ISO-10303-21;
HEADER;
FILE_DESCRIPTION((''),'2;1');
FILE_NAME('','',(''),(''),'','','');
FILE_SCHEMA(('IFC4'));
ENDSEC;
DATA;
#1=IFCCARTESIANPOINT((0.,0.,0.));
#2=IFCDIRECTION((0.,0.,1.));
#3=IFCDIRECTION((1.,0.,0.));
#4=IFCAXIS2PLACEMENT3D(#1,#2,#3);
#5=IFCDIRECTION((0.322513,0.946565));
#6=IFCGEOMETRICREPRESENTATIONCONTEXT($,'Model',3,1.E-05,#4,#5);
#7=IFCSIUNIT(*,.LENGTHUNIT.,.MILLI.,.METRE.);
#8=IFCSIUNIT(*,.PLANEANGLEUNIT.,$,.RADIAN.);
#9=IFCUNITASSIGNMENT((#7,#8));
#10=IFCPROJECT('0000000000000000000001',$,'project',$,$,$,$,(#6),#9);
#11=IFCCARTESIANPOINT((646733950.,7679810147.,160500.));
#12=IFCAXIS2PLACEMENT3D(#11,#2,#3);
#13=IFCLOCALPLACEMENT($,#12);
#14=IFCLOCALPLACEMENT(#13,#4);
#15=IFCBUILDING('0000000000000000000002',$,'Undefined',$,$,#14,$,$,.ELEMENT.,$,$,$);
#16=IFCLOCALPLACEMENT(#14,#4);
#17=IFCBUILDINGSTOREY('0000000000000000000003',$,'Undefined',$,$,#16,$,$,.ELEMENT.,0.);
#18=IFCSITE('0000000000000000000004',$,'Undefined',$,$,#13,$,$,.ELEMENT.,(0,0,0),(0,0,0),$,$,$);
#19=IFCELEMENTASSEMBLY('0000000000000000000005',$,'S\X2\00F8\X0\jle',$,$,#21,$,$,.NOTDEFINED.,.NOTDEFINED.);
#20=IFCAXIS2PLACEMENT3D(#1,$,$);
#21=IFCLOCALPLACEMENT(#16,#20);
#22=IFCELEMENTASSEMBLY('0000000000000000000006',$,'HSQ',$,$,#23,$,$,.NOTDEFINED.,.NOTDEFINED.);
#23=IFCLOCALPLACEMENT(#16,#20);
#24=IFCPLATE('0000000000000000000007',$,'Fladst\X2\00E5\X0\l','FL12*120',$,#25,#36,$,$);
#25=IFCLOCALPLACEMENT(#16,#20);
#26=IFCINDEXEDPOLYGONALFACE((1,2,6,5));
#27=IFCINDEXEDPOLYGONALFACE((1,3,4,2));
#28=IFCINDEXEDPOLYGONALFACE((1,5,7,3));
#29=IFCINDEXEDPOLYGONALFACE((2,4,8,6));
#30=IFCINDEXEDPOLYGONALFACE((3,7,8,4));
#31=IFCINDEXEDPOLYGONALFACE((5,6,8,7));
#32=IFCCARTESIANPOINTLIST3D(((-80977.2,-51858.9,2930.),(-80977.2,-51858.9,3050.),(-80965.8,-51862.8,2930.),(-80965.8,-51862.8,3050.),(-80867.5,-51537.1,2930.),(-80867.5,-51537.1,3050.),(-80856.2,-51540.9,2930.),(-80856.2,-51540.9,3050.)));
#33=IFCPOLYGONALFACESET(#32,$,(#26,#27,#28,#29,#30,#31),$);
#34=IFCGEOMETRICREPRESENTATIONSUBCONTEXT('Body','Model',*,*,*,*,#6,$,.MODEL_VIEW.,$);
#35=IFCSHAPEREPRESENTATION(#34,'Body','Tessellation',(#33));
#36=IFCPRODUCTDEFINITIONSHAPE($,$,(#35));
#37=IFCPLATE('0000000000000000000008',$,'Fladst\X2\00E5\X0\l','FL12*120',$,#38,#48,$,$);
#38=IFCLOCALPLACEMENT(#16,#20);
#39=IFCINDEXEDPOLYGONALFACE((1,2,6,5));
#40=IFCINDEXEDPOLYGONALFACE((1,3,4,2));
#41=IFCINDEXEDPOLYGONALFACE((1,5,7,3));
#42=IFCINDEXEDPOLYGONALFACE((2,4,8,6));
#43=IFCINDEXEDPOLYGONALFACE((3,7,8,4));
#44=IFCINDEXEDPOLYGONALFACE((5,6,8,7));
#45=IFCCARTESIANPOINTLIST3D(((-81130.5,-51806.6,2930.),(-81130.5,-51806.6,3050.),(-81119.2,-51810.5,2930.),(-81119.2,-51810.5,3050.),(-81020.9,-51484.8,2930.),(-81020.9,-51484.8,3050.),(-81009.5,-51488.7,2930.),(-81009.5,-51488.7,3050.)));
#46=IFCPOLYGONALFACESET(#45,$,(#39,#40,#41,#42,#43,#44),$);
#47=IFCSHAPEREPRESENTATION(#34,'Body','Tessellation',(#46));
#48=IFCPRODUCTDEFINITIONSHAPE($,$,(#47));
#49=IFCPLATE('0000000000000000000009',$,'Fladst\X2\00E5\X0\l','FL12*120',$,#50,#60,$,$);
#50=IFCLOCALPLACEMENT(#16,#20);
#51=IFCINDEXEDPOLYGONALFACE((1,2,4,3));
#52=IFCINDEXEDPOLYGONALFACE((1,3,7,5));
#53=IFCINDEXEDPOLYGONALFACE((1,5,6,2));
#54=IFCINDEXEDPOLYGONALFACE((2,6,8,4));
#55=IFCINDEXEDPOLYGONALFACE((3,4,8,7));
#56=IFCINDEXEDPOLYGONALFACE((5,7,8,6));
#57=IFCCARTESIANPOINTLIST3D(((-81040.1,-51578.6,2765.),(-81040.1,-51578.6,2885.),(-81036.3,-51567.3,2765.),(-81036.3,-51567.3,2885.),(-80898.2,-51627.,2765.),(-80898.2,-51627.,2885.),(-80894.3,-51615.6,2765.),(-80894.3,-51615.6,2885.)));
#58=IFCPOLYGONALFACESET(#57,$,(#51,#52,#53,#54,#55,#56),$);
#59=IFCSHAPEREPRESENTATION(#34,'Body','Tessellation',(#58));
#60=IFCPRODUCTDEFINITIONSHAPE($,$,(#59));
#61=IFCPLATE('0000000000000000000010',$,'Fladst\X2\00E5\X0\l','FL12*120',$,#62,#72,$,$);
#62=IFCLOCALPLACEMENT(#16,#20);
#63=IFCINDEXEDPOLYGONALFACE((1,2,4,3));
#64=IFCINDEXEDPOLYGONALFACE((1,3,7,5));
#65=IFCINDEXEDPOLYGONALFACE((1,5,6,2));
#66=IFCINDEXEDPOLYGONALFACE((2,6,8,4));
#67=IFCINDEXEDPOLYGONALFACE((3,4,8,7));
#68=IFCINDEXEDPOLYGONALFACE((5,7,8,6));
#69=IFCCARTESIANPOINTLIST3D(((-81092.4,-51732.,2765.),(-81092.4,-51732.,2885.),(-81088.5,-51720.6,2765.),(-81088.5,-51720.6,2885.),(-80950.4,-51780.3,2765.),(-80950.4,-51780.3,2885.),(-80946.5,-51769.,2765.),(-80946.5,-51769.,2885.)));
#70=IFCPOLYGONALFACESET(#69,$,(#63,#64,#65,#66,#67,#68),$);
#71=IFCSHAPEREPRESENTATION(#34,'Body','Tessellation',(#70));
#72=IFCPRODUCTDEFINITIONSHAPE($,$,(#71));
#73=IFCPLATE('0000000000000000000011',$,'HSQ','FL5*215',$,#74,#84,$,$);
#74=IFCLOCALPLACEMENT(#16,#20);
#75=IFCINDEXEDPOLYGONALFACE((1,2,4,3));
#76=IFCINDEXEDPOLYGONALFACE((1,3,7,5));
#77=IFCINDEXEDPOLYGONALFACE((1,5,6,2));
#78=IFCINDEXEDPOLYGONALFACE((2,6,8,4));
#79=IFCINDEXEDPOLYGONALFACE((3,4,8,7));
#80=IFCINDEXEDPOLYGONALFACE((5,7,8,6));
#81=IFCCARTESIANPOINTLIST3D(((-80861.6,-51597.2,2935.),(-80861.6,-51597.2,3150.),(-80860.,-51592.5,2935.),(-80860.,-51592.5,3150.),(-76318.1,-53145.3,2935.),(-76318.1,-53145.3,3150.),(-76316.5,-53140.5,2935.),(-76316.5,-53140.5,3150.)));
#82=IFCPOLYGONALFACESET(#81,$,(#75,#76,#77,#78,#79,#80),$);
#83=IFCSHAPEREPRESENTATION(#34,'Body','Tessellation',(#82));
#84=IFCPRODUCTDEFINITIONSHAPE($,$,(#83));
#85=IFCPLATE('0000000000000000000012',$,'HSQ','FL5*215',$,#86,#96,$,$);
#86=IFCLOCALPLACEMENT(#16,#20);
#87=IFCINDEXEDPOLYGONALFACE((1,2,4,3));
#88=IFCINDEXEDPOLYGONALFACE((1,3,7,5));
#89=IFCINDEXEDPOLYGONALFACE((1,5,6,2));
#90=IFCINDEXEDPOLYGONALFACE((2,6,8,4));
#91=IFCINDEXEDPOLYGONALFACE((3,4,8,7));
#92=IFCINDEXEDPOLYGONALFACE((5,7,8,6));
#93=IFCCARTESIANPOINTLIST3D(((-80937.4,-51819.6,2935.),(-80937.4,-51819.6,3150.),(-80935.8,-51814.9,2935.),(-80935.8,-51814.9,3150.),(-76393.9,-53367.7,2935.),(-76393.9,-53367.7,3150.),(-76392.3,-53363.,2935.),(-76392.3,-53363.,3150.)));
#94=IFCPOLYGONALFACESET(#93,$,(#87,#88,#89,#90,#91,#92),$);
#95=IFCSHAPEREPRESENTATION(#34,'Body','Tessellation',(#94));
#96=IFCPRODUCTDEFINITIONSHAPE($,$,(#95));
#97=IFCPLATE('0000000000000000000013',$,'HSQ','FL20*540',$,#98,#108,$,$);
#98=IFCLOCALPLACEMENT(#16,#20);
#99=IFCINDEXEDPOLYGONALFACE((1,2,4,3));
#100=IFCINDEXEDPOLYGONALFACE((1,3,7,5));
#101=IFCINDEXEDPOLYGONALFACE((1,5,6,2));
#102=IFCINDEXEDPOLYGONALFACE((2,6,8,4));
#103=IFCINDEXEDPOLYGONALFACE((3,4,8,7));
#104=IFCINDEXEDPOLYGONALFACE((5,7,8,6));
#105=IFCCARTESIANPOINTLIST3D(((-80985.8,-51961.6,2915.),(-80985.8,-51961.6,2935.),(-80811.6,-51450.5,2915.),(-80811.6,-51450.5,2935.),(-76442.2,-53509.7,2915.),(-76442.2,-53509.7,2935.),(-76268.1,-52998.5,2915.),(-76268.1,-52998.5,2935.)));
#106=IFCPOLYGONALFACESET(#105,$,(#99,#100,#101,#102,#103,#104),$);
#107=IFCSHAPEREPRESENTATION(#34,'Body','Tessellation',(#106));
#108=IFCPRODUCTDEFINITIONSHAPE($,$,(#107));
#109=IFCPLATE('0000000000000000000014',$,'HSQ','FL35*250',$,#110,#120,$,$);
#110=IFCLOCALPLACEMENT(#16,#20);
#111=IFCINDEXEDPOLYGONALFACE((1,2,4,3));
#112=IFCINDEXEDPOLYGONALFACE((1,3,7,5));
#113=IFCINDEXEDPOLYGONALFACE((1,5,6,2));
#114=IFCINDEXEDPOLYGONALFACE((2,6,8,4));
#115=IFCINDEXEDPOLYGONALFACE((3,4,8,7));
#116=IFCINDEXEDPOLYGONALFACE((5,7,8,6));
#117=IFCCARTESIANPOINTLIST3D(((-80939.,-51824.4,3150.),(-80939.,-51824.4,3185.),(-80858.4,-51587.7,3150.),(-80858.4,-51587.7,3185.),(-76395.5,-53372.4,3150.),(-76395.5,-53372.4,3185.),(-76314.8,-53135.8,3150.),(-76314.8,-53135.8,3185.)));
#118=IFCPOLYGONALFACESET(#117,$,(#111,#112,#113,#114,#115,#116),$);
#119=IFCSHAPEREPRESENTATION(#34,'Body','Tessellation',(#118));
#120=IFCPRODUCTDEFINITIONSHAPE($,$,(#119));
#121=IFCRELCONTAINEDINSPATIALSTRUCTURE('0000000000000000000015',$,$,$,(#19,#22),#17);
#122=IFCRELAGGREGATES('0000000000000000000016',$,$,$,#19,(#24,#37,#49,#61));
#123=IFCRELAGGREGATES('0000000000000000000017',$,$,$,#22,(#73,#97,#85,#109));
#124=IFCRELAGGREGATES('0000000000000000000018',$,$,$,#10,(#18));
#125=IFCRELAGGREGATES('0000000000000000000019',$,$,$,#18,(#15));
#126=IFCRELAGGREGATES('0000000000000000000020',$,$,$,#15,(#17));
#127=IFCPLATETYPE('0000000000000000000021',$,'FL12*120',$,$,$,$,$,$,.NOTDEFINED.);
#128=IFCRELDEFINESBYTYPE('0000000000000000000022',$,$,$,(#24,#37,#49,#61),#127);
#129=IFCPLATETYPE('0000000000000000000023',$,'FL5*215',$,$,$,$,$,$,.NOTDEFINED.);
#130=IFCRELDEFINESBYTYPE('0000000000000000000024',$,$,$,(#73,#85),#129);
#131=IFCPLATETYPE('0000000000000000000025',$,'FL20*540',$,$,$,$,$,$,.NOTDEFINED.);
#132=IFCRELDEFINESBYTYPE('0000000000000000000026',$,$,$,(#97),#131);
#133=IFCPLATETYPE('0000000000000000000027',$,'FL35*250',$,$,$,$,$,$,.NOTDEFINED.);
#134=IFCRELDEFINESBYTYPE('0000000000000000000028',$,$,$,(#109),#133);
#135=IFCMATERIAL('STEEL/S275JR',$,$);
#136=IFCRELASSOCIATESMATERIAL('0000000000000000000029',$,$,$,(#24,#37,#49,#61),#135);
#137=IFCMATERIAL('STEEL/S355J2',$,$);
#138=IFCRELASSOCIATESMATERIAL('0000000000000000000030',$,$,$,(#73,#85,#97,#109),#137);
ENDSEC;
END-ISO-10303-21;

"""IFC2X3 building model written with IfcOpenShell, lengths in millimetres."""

from ifc_helpers import new_model, si_unit, direction, frame, origin_with_axes, place, context, subcontext, project, spatial, polyline, outline, extrude, material, type_object, element, aggregate, save


model = new_model("IFC2X3")

# Units and contexts
model_context = context("Model", 3, precision=1e-05, world=origin_with_axes(), true_north=direction((0.322513, 0.946565)))
body_context = subcontext(model_context, "Body", "Model", "MODEL_VIEW")
ifc_project = project(units=[si_unit("LENGTHUNIT", "METRE", prefix="MILLI"), si_unit("PLANEANGLEUNIT", "RADIAN")], contexts=[model_context])

# Site, building, storey
site_placement = place(None, frame((646733950.0, 7679810147.0, 160500.0), z_axis=(0.0, 0.0, 1.0), x_axis=(1.0, 0.0, 0.0)))
site = spatial("IfcSite", under=ifc_project, at=site_placement, Name="Undefined", CompositionType="ELEMENT", RefLatitude=(0, 0, 0), RefLongitude=(0, 0, 0))
building_placement = place(site_placement, origin_with_axes())
building = spatial("IfcBuilding", under=site, at=building_placement, Name="Undefined", CompositionType="ELEMENT")
storey_placement = place(building_placement, origin_with_axes())
storey = spatial("IfcBuildingStorey", under=building, at=storey_placement, Name="Undefined", CompositionType="ELEMENT", Elevation=0.0)

# Element assembly
assembly_1_placement = place(storey_placement, origin_with_axes())
assembly_1 = element("IfcElementAssembly", 1, at=assembly_1_placement, inside=storey, Name="Søjle", AssemblyPlace="NOTDEFINED", PredefinedType="NOTDEFINED")

# Shared definitions
ifc_material_1 = material(Name="STEEL/S275JR")

# Element assembly
assembly_2_placement = place(storey_placement, origin_with_axes())
assembly_2 = element("IfcElementAssembly", 2, at=assembly_2_placement, inside=storey, Name="HSQ", AssemblyPlace="NOTDEFINED", PredefinedType="NOTDEFINED")

# Plates
plate_type_1 = type_object("IfcPlateType", Name="FL12*120", PredefinedType="NOTDEFINED")
plate_1_placement = place(assembly_1_placement, frame((-80861.8, -51539.0, 3050.0), z_axis=(0.946565, -0.322513, 0.0), x_axis=(-0.322513, -0.946565, 0.0)))
plate_1 = element("IfcPlate", 3, at=plate_1_placement, type_object=plate_type_1, material=ifc_material_1, Name="Fladstål", Description="FL12*120", context=body_context, shape_type="SweptSolid", body=[
    extrude(outline(polyline([(0.0, 0.0), (340.0, 0.0), (340.0, 120.0), (0.0, 120.0), (0.0, 0.0)])), frame((0.0, 0.0, -6.0), z_axis=(0.0, 0.0, 1.0), x_axis=(1.0, 0.0, 0.0)), (0.0, 0.0, 1.0), 12.0),
])
plate_2_placement = place(assembly_1_placement, frame((-81015.2, -51486.8, 3050.0), z_axis=(0.946565, -0.322513, 0.0), x_axis=(-0.322513, -0.946565, 0.0)))
plate_2 = element("IfcPlate", 4, at=plate_2_placement, type_object=plate_type_1, material=ifc_material_1, Name="Fladstål", Description="FL12*120", context=body_context, shape_type="SweptSolid", body=[
    extrude(outline(polyline([(0.0, 0.0), (340.0, 0.0), (340.0, 120.0), (0.0, 120.0), (0.0, 0.0)])), frame((0.0, 0.0, -6.0), z_axis=(0.0, 0.0, 1.0), x_axis=(1.0, 0.0, 0.0)), (0.0, 0.0, 1.0), 12.0),
])
plate_3_placement = place(assembly_1_placement, frame((-80896.2, -51621.3, 2885.0), z_axis=(-0.322513, -0.946565, 0.0), x_axis=(-0.946565, 0.322513, 0.0)))
plate_3 = element("IfcPlate", 5, at=plate_3_placement, type_object=plate_type_1, material=ifc_material_1, Name="Fladstål", Description="FL12*120", context=body_context, shape_type="SweptSolid", body=[
    extrude(outline(polyline([(0.0, 0.0), (150.0, 0.0), (150.0, 120.0), (0.0, 120.0), (0.0, 0.0)])), frame((0.0, 0.0, -6.0), z_axis=(0.0, 0.0, 1.0), x_axis=(1.0, 0.0, 0.0)), (0.0, 0.0, 1.0), 12.0),
])
plate_4_placement = place(assembly_1_placement, frame((-80948.5, -51774.7, 2885.0), z_axis=(-0.322513, -0.946565, 0.0), x_axis=(-0.946565, 0.322513, 0.0)))
plate_4 = element("IfcPlate", 6, at=plate_4_placement, type_object=plate_type_1, material=ifc_material_1, Name="Fladstål", Description="FL12*120", context=body_context, shape_type="SweptSolid", body=[
    extrude(outline(polyline([(0.0, 0.0), (150.0, 0.0), (150.0, 120.0), (0.0, 120.0), (0.0, 0.0)])), frame((0.0, 0.0, -6.0), z_axis=(0.0, 0.0, 1.0), x_axis=(1.0, 0.0, 0.0)), (0.0, 0.0, 1.0), 12.0),
])
ifc_material_2 = material(Name="STEEL/S355J2")
plate_type_2 = type_object("IfcPlateType", Name="FL5*215", PredefinedType="NOTDEFINED")
plate_5_placement = place(assembly_2_placement, frame((-80860.8, -51594.8, 3042.5), z_axis=(-0.322513, -0.946565, 0.0), x_axis=(0.946565, -0.322513, 0.0)))
plate_5 = element("IfcPlate", 7, at=plate_5_placement, type_object=plate_type_2, material=ifc_material_2, Name="HSQ", Description="FL5*215", context=body_context, shape_type="SweptSolid", body=[
    extrude(outline(polyline([(0.0, -107.5), (0.0, 107.5), (4800.0, 107.5), (4800.0, -107.5), (0.0, -107.5)])), frame((0.0, 0.0, -2.5), z_axis=(0.0, 0.0, 1.0), x_axis=(1.0, 0.0, 0.0)), (0.0, 0.0, 1.0), 5.0),
])
plate_6_placement = place(assembly_2_placement, frame((-80936.6, -51817.3, 3042.5), z_axis=(-0.322513, -0.946565, 0.0), x_axis=(0.946565, -0.322513, 0.0)))
plate_6 = element("IfcPlate", 8, at=plate_6_placement, type_object=plate_type_2, material=ifc_material_2, Name="HSQ", Description="FL5*215", context=body_context, shape_type="SweptSolid", body=[
    extrude(outline(polyline([(0.0, -107.5), (0.0, 107.5), (4800.0, 107.5), (4800.0, -107.5), (0.0, -107.5)])), frame((0.0, 0.0, -2.5), z_axis=(0.0, 0.0, 1.0), x_axis=(1.0, 0.0, 0.0)), (0.0, 0.0, 1.0), 5.0),
])
plate_type_3 = type_object("IfcPlateType", Name="FL20*540", PredefinedType="NOTDEFINED")
plate_7_placement = place(assembly_2_placement, frame((-80898.7, -51706.0, 2925.0), z_axis=(0.0, 0.0, 1.0), x_axis=(0.946565, -0.322513, 0.0)))
plate_7 = element("IfcPlate", 9, at=plate_7_placement, type_object=plate_type_3, material=ifc_material_2, Name="HSQ", Description="FL20*540", context=body_context, shape_type="SweptSolid", body=[
    extrude(outline(polyline([(0.0, -270.0), (0.0, 270.0), (4800.0, 270.0), (4800.0, -270.0), (0.0, -270.0)])), frame((0.0, 0.0, -10.0), z_axis=(0.0, 0.0, 1.0), x_axis=(1.0, 0.0, 0.0)), (0.0, 0.0, 1.0), 20.0),
])
plate_type_4 = type_object("IfcPlateType", Name="FL35*250", PredefinedType="NOTDEFINED")
plate_8_placement = place(assembly_2_placement, frame((-80898.7, -51706.0, 3167.5), z_axis=(0.0, 0.0, 1.0), x_axis=(0.946565, -0.322513, 0.0)))
plate_8 = element("IfcPlate", 10, at=plate_8_placement, type_object=plate_type_4, material=ifc_material_2, Name="HSQ", Description="FL35*250", context=body_context, shape_type="SweptSolid", body=[
    extrude(outline(polyline([(0.0, -125.0), (0.0, 125.0), (4800.0, 125.0), (4800.0, -125.0), (0.0, -125.0)])), frame((0.0, 0.0, -17.5), z_axis=(0.0, 0.0, 1.0), x_axis=(1.0, 0.0, 0.0)), (0.0, 0.0, 1.0), 35.0),
])

aggregate(assembly_1, [plate_1, plate_2, plate_3, plate_4])
aggregate(assembly_2, [plate_5, plate_7, plate_6, plate_8])

save(model, "model.ifc")
